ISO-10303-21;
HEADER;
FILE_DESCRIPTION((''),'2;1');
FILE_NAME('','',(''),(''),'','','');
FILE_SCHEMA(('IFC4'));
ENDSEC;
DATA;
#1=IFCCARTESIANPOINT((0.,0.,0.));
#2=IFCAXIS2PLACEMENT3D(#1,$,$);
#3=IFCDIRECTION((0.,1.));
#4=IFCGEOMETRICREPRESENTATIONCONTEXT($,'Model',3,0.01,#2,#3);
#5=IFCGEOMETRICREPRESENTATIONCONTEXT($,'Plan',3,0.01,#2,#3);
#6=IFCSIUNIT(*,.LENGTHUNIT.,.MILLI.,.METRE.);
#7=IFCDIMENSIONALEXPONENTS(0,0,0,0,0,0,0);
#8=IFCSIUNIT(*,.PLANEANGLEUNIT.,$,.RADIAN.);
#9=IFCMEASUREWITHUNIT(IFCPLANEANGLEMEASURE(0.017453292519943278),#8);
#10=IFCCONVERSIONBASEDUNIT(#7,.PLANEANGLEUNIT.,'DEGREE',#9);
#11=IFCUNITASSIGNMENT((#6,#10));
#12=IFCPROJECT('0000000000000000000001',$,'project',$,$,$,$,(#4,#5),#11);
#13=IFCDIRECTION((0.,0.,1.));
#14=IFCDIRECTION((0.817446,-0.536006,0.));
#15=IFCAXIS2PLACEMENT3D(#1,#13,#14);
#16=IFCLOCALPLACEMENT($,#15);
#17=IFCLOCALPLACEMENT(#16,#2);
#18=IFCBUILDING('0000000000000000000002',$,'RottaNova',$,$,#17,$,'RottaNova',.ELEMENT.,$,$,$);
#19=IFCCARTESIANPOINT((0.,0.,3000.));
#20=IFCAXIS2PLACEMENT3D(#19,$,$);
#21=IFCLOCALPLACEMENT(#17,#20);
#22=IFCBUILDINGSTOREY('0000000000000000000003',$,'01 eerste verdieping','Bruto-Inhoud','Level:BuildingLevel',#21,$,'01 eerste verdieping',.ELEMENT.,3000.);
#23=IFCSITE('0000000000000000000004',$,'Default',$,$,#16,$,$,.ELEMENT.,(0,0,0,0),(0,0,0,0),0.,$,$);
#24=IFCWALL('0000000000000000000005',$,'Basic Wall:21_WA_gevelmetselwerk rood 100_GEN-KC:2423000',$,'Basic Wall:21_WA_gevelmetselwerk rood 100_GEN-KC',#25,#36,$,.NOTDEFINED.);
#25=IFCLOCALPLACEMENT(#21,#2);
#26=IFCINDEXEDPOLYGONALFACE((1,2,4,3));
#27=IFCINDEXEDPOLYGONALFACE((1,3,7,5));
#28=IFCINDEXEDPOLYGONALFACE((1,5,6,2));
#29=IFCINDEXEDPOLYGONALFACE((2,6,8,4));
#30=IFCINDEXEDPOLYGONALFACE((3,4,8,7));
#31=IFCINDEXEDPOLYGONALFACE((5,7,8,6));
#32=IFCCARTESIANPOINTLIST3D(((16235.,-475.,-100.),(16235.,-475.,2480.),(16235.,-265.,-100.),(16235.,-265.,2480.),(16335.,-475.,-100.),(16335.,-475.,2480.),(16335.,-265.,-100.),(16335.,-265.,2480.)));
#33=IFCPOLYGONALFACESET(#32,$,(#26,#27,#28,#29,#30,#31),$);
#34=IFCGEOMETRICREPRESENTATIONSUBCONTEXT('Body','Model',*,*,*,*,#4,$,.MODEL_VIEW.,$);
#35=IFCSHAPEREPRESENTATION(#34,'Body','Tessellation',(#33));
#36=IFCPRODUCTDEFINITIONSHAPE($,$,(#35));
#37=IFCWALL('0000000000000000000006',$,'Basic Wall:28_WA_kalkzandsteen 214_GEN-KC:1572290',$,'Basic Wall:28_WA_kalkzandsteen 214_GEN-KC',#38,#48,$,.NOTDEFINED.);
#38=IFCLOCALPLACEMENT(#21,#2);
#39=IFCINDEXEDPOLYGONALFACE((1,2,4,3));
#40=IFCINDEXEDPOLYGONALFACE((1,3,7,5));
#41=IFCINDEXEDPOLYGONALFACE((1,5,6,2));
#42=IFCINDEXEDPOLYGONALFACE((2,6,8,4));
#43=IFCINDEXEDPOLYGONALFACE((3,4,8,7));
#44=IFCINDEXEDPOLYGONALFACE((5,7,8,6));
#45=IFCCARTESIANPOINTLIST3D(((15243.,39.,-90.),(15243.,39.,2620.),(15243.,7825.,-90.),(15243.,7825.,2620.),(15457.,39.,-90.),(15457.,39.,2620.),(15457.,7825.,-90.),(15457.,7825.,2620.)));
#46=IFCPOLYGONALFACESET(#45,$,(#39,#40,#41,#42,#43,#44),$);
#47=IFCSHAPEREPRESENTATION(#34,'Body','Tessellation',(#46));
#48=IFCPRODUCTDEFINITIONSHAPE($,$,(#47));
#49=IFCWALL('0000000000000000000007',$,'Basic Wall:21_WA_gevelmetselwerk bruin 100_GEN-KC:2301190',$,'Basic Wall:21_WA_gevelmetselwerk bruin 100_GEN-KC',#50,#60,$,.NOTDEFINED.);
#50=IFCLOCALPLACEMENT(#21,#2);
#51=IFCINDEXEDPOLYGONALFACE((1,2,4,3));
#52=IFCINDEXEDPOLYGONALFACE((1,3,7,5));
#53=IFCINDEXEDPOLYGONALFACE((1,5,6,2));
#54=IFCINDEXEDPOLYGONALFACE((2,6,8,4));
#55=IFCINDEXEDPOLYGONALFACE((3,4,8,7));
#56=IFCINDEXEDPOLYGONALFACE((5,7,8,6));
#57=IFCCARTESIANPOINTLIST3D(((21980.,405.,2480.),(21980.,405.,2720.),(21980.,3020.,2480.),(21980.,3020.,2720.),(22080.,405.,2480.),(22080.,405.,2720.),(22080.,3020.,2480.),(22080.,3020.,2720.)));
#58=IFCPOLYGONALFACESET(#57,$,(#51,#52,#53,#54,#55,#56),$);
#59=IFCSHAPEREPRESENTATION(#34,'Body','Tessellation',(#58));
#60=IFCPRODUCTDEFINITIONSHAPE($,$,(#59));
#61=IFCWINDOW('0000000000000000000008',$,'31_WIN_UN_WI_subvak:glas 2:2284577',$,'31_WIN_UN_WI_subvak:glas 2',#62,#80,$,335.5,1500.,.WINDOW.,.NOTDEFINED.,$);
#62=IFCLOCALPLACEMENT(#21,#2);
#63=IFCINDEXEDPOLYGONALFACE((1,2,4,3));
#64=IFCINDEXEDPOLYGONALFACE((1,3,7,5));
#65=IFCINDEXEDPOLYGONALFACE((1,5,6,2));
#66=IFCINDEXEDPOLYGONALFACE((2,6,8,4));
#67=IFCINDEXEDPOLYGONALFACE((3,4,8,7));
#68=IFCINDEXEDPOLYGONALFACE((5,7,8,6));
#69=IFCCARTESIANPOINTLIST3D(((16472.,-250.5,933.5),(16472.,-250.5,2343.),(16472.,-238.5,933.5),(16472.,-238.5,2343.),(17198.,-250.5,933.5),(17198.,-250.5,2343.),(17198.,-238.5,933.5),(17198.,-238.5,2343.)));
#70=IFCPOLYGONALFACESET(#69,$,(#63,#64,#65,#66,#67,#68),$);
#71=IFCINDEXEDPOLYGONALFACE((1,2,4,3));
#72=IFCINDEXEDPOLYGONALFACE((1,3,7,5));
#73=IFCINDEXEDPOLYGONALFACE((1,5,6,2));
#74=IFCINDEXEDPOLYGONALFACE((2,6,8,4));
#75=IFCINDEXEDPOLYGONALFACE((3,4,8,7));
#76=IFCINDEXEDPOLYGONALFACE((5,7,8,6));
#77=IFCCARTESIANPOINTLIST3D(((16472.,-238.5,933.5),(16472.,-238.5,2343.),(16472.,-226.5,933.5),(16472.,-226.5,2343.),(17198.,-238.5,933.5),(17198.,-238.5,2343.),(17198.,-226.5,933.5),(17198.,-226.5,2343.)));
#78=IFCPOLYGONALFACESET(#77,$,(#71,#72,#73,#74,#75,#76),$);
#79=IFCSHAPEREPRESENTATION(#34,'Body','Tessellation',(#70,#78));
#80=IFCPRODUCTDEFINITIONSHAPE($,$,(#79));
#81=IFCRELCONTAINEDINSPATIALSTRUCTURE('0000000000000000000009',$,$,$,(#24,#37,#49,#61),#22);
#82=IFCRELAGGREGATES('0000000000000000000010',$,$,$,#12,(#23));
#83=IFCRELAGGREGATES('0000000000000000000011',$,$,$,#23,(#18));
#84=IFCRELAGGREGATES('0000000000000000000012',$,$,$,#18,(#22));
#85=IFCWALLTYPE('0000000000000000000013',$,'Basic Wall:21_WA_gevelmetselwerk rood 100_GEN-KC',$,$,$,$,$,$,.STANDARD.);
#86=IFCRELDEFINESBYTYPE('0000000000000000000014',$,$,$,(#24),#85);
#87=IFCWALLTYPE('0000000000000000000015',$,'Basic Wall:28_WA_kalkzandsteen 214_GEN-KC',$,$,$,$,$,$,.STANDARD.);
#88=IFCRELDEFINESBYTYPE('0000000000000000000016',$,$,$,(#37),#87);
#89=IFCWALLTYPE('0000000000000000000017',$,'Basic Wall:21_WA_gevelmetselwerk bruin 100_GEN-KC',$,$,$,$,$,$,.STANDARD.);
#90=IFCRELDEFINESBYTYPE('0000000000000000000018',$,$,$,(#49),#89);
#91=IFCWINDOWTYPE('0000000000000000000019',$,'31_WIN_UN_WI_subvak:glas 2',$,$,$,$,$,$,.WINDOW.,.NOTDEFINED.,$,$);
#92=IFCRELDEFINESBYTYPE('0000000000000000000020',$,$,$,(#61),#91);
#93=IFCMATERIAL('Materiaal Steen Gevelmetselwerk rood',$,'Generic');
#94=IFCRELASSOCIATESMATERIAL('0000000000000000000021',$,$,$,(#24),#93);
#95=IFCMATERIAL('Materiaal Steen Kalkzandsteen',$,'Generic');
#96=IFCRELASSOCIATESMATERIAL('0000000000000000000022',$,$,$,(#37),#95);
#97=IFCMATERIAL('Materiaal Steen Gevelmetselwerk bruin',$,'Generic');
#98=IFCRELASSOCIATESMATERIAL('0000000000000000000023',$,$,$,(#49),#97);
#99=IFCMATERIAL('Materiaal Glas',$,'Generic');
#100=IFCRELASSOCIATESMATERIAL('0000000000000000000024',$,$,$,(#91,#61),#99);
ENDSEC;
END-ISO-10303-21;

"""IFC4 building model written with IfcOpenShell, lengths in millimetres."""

from ifc_helpers import new_model, entity, si_unit, converted_unit, direction, frame, origin, place, context, subcontext, project, spatial, indexed_curve, outline, extrude, source, transform, mapped, material, type_object, type_shapes, element, save


model = new_model("IFC4")

# Units and contexts
model_context = context("Model", 3, precision=0.01, world=origin(), true_north=direction((0.0, 1.0)))
plan_context = context("Plan", 3, precision=0.01, world=origin(), true_north=direction((0.0, 1.0)))
body_context = subcontext(model_context, "Body", "Model", "MODEL_VIEW")
ifc_project = project(units=[si_unit("LENGTHUNIT", "METRE", prefix="MILLI"), converted_unit("PLANEANGLEUNIT", "DEGREE", entity("IfcPlaneAngleMeasure", 0.017453292519943278), si_unit("PLANEANGLEUNIT", "RADIAN"), dimensions=[0, 0, 0, 0, 0, 0, 0])], contexts=[model_context, plan_context])

# Site, building, storey
site_placement = place(None, frame((0.0, 0.0, 0.0), z_axis=(0.0, 0.0, 1.0), x_axis=(0.817446, -0.536006, 0.0)))
site = spatial("IfcSite", under=ifc_project, at=site_placement, Name="Default", CompositionType="ELEMENT", RefLatitude=(0, 0, 0, 0), RefLongitude=(0, 0, 0, 0), RefElevation=0.0)
building_placement = place(site_placement, origin())
building = spatial("IfcBuilding", under=site, at=building_placement, Name="RottaNova", LongName="RottaNova", CompositionType="ELEMENT")
storey_placement = place(building_placement, frame((0.0, 0.0, 3000.0)))
storey = spatial("IfcBuildingStorey", under=building, at=storey_placement, Name="01 eerste verdieping", Description="Bruto-Inhoud", ObjectType="Level:BuildingLevel", LongName="01 eerste verdieping", CompositionType="ELEMENT", Elevation=3000.0)

# Shared definitions
ifc_material_1 = material(Name="Materiaal Glas", Category="Generic")

# Walls
ifc_material_2 = material(Name="Materiaal Steen Gevelmetselwerk rood", Category="Generic")
wall_type_1 = type_object("IfcWallType", Name="Basic Wall:21_WA_gevelmetselwerk rood 100_GEN-KC", PredefinedType="STANDARD")
wall_1_placement = place(storey_placement, frame((16285.0, -265.0, -100.0), z_axis=(0.0, 0.0, 1.0), x_axis=(0.0, -1.0, 0.0)))
element("IfcWall", 1, at=wall_1_placement, inside=storey, type_object=wall_type_1, material=ifc_material_2, Name="Basic Wall:21_WA_gevelmetselwerk rood 100_GEN-KC:2423000", ObjectType="Basic Wall:21_WA_gevelmetselwerk rood 100_GEN-KC", PredefinedType="NOTDEFINED", context=body_context, shape_type="SweptSolid", body=[
    extrude(outline(indexed_curve([(210.0, 50.0), (0.0, 50.0), (0.0, -50.0), (210.0, -50.0), (210.0, 50.0)], self_intersect=False)), origin(), (0.0, 0.0, 1.0), 2580.0),
])
ifc_material_3 = material(Name="Materiaal Steen Kalkzandsteen", Category="Generic")
wall_type_2 = type_object("IfcWallType", Name="Basic Wall:28_WA_kalkzandsteen 214_GEN-KC", PredefinedType="STANDARD")
wall_2_placement = place(storey_placement, frame((15350.0, 39.0, -90.0), z_axis=(0.0, 0.0, 1.0), x_axis=(0.0, 1.0, 0.0)))
element("IfcWall", 2, at=wall_2_placement, inside=storey, type_object=wall_type_2, material=ifc_material_3, Name="Basic Wall:28_WA_kalkzandsteen 214_GEN-KC:1572290", ObjectType="Basic Wall:28_WA_kalkzandsteen 214_GEN-KC", PredefinedType="NOTDEFINED", context=body_context, shape_type="SweptSolid", body=[
    extrude(outline(indexed_curve([(-3893.0, -107.0), (3893.0, -107.0), (3893.0, 107.0), (-3893.0, 107.0), (-3893.0, -107.0)], self_intersect=False)), frame((3893.0, 0.0, 0.0)), (0.0, 0.0, 1.0), 2710.0),
])
ifc_material_4 = material(Name="Materiaal Steen Gevelmetselwerk bruin", Category="Generic")
wall_type_3 = type_object("IfcWallType", Name="Basic Wall:21_WA_gevelmetselwerk bruin 100_GEN-KC", PredefinedType="STANDARD")
wall_3_placement = place(storey_placement, frame((22030.0, 3020.0, 2480.0), z_axis=(0.0, 0.0, 1.0), x_axis=(0.0, -1.0, 0.0)))
element("IfcWall", 3, at=wall_3_placement, inside=storey, type_object=wall_type_3, material=ifc_material_4, Name="Basic Wall:21_WA_gevelmetselwerk bruin 100_GEN-KC:2301190", ObjectType="Basic Wall:21_WA_gevelmetselwerk bruin 100_GEN-KC", PredefinedType="NOTDEFINED", context=body_context, shape_type="SweptSolid", body=[
    extrude(outline(indexed_curve([(2615.0, 50.0), (0.0, 50.0), (0.0, -50.0), (2615.0, -50.0), (2615.0, 50.0)], self_intersect=False)), origin(), (0.0, 0.0, 1.0), 240.0),
])

# Window
window_type = type_object("IfcWindowType", Name="31_WIN_UN_WI_subvak:glas 2", PartitioningType="NOTDEFINED", PredefinedType="WINDOW", material=ifc_material_1)
shared_shape_1 = source(origin(), body_context, "Body", "SweptSolid", [
    extrude(outline(indexed_curve([(-6.0, -363.0), (6.0, -363.0), (6.0, 363.0), (-6.0, 363.0), (-6.0, -363.0)], self_intersect=False)), frame((0.0, 6.0, 0.0), z_axis=(0.0, 0.0, 1.0), x_axis=(0.0, -1.0, 0.0)), (0.0, 0.0, 1.0), 1409.5),
    extrude(outline(indexed_curve([(-6.0, -363.0), (6.0, -363.0), (6.0, 363.0), (-6.0, 363.0), (-6.0, -363.0)], self_intersect=False)), frame((0.0, -6.0, 0.0), z_axis=(0.0, 0.0, 1.0), x_axis=(0.0, -1.0, 0.0)), (0.0, 0.0, 1.0), 1409.5),
])
type_shapes(window_type, [shared_shape_1])
window_1_placement = place(storey_placement, frame((16835.0, -238.5, 933.5), z_axis=(0.0, 0.0, 1.0), x_axis=(-1.0, 0.0, 0.0)))
element("IfcWindow", 4, at=window_1_placement, inside=storey, type_object=window_type, material=ifc_material_1, Name="31_WIN_UN_WI_subvak:glas 2:2284577", ObjectType="31_WIN_UN_WI_subvak:glas 2", OverallHeight=335.5, OverallWidth=1500.0, PartitioningType="NOTDEFINED", PredefinedType="WINDOW", context=body_context, shape_type="MappedRepresentation", body=[
    mapped(shared_shape_1, transform((0.0, 0.0, 0.0), scale=1.0)),
])

save(model, "model.ifc")
